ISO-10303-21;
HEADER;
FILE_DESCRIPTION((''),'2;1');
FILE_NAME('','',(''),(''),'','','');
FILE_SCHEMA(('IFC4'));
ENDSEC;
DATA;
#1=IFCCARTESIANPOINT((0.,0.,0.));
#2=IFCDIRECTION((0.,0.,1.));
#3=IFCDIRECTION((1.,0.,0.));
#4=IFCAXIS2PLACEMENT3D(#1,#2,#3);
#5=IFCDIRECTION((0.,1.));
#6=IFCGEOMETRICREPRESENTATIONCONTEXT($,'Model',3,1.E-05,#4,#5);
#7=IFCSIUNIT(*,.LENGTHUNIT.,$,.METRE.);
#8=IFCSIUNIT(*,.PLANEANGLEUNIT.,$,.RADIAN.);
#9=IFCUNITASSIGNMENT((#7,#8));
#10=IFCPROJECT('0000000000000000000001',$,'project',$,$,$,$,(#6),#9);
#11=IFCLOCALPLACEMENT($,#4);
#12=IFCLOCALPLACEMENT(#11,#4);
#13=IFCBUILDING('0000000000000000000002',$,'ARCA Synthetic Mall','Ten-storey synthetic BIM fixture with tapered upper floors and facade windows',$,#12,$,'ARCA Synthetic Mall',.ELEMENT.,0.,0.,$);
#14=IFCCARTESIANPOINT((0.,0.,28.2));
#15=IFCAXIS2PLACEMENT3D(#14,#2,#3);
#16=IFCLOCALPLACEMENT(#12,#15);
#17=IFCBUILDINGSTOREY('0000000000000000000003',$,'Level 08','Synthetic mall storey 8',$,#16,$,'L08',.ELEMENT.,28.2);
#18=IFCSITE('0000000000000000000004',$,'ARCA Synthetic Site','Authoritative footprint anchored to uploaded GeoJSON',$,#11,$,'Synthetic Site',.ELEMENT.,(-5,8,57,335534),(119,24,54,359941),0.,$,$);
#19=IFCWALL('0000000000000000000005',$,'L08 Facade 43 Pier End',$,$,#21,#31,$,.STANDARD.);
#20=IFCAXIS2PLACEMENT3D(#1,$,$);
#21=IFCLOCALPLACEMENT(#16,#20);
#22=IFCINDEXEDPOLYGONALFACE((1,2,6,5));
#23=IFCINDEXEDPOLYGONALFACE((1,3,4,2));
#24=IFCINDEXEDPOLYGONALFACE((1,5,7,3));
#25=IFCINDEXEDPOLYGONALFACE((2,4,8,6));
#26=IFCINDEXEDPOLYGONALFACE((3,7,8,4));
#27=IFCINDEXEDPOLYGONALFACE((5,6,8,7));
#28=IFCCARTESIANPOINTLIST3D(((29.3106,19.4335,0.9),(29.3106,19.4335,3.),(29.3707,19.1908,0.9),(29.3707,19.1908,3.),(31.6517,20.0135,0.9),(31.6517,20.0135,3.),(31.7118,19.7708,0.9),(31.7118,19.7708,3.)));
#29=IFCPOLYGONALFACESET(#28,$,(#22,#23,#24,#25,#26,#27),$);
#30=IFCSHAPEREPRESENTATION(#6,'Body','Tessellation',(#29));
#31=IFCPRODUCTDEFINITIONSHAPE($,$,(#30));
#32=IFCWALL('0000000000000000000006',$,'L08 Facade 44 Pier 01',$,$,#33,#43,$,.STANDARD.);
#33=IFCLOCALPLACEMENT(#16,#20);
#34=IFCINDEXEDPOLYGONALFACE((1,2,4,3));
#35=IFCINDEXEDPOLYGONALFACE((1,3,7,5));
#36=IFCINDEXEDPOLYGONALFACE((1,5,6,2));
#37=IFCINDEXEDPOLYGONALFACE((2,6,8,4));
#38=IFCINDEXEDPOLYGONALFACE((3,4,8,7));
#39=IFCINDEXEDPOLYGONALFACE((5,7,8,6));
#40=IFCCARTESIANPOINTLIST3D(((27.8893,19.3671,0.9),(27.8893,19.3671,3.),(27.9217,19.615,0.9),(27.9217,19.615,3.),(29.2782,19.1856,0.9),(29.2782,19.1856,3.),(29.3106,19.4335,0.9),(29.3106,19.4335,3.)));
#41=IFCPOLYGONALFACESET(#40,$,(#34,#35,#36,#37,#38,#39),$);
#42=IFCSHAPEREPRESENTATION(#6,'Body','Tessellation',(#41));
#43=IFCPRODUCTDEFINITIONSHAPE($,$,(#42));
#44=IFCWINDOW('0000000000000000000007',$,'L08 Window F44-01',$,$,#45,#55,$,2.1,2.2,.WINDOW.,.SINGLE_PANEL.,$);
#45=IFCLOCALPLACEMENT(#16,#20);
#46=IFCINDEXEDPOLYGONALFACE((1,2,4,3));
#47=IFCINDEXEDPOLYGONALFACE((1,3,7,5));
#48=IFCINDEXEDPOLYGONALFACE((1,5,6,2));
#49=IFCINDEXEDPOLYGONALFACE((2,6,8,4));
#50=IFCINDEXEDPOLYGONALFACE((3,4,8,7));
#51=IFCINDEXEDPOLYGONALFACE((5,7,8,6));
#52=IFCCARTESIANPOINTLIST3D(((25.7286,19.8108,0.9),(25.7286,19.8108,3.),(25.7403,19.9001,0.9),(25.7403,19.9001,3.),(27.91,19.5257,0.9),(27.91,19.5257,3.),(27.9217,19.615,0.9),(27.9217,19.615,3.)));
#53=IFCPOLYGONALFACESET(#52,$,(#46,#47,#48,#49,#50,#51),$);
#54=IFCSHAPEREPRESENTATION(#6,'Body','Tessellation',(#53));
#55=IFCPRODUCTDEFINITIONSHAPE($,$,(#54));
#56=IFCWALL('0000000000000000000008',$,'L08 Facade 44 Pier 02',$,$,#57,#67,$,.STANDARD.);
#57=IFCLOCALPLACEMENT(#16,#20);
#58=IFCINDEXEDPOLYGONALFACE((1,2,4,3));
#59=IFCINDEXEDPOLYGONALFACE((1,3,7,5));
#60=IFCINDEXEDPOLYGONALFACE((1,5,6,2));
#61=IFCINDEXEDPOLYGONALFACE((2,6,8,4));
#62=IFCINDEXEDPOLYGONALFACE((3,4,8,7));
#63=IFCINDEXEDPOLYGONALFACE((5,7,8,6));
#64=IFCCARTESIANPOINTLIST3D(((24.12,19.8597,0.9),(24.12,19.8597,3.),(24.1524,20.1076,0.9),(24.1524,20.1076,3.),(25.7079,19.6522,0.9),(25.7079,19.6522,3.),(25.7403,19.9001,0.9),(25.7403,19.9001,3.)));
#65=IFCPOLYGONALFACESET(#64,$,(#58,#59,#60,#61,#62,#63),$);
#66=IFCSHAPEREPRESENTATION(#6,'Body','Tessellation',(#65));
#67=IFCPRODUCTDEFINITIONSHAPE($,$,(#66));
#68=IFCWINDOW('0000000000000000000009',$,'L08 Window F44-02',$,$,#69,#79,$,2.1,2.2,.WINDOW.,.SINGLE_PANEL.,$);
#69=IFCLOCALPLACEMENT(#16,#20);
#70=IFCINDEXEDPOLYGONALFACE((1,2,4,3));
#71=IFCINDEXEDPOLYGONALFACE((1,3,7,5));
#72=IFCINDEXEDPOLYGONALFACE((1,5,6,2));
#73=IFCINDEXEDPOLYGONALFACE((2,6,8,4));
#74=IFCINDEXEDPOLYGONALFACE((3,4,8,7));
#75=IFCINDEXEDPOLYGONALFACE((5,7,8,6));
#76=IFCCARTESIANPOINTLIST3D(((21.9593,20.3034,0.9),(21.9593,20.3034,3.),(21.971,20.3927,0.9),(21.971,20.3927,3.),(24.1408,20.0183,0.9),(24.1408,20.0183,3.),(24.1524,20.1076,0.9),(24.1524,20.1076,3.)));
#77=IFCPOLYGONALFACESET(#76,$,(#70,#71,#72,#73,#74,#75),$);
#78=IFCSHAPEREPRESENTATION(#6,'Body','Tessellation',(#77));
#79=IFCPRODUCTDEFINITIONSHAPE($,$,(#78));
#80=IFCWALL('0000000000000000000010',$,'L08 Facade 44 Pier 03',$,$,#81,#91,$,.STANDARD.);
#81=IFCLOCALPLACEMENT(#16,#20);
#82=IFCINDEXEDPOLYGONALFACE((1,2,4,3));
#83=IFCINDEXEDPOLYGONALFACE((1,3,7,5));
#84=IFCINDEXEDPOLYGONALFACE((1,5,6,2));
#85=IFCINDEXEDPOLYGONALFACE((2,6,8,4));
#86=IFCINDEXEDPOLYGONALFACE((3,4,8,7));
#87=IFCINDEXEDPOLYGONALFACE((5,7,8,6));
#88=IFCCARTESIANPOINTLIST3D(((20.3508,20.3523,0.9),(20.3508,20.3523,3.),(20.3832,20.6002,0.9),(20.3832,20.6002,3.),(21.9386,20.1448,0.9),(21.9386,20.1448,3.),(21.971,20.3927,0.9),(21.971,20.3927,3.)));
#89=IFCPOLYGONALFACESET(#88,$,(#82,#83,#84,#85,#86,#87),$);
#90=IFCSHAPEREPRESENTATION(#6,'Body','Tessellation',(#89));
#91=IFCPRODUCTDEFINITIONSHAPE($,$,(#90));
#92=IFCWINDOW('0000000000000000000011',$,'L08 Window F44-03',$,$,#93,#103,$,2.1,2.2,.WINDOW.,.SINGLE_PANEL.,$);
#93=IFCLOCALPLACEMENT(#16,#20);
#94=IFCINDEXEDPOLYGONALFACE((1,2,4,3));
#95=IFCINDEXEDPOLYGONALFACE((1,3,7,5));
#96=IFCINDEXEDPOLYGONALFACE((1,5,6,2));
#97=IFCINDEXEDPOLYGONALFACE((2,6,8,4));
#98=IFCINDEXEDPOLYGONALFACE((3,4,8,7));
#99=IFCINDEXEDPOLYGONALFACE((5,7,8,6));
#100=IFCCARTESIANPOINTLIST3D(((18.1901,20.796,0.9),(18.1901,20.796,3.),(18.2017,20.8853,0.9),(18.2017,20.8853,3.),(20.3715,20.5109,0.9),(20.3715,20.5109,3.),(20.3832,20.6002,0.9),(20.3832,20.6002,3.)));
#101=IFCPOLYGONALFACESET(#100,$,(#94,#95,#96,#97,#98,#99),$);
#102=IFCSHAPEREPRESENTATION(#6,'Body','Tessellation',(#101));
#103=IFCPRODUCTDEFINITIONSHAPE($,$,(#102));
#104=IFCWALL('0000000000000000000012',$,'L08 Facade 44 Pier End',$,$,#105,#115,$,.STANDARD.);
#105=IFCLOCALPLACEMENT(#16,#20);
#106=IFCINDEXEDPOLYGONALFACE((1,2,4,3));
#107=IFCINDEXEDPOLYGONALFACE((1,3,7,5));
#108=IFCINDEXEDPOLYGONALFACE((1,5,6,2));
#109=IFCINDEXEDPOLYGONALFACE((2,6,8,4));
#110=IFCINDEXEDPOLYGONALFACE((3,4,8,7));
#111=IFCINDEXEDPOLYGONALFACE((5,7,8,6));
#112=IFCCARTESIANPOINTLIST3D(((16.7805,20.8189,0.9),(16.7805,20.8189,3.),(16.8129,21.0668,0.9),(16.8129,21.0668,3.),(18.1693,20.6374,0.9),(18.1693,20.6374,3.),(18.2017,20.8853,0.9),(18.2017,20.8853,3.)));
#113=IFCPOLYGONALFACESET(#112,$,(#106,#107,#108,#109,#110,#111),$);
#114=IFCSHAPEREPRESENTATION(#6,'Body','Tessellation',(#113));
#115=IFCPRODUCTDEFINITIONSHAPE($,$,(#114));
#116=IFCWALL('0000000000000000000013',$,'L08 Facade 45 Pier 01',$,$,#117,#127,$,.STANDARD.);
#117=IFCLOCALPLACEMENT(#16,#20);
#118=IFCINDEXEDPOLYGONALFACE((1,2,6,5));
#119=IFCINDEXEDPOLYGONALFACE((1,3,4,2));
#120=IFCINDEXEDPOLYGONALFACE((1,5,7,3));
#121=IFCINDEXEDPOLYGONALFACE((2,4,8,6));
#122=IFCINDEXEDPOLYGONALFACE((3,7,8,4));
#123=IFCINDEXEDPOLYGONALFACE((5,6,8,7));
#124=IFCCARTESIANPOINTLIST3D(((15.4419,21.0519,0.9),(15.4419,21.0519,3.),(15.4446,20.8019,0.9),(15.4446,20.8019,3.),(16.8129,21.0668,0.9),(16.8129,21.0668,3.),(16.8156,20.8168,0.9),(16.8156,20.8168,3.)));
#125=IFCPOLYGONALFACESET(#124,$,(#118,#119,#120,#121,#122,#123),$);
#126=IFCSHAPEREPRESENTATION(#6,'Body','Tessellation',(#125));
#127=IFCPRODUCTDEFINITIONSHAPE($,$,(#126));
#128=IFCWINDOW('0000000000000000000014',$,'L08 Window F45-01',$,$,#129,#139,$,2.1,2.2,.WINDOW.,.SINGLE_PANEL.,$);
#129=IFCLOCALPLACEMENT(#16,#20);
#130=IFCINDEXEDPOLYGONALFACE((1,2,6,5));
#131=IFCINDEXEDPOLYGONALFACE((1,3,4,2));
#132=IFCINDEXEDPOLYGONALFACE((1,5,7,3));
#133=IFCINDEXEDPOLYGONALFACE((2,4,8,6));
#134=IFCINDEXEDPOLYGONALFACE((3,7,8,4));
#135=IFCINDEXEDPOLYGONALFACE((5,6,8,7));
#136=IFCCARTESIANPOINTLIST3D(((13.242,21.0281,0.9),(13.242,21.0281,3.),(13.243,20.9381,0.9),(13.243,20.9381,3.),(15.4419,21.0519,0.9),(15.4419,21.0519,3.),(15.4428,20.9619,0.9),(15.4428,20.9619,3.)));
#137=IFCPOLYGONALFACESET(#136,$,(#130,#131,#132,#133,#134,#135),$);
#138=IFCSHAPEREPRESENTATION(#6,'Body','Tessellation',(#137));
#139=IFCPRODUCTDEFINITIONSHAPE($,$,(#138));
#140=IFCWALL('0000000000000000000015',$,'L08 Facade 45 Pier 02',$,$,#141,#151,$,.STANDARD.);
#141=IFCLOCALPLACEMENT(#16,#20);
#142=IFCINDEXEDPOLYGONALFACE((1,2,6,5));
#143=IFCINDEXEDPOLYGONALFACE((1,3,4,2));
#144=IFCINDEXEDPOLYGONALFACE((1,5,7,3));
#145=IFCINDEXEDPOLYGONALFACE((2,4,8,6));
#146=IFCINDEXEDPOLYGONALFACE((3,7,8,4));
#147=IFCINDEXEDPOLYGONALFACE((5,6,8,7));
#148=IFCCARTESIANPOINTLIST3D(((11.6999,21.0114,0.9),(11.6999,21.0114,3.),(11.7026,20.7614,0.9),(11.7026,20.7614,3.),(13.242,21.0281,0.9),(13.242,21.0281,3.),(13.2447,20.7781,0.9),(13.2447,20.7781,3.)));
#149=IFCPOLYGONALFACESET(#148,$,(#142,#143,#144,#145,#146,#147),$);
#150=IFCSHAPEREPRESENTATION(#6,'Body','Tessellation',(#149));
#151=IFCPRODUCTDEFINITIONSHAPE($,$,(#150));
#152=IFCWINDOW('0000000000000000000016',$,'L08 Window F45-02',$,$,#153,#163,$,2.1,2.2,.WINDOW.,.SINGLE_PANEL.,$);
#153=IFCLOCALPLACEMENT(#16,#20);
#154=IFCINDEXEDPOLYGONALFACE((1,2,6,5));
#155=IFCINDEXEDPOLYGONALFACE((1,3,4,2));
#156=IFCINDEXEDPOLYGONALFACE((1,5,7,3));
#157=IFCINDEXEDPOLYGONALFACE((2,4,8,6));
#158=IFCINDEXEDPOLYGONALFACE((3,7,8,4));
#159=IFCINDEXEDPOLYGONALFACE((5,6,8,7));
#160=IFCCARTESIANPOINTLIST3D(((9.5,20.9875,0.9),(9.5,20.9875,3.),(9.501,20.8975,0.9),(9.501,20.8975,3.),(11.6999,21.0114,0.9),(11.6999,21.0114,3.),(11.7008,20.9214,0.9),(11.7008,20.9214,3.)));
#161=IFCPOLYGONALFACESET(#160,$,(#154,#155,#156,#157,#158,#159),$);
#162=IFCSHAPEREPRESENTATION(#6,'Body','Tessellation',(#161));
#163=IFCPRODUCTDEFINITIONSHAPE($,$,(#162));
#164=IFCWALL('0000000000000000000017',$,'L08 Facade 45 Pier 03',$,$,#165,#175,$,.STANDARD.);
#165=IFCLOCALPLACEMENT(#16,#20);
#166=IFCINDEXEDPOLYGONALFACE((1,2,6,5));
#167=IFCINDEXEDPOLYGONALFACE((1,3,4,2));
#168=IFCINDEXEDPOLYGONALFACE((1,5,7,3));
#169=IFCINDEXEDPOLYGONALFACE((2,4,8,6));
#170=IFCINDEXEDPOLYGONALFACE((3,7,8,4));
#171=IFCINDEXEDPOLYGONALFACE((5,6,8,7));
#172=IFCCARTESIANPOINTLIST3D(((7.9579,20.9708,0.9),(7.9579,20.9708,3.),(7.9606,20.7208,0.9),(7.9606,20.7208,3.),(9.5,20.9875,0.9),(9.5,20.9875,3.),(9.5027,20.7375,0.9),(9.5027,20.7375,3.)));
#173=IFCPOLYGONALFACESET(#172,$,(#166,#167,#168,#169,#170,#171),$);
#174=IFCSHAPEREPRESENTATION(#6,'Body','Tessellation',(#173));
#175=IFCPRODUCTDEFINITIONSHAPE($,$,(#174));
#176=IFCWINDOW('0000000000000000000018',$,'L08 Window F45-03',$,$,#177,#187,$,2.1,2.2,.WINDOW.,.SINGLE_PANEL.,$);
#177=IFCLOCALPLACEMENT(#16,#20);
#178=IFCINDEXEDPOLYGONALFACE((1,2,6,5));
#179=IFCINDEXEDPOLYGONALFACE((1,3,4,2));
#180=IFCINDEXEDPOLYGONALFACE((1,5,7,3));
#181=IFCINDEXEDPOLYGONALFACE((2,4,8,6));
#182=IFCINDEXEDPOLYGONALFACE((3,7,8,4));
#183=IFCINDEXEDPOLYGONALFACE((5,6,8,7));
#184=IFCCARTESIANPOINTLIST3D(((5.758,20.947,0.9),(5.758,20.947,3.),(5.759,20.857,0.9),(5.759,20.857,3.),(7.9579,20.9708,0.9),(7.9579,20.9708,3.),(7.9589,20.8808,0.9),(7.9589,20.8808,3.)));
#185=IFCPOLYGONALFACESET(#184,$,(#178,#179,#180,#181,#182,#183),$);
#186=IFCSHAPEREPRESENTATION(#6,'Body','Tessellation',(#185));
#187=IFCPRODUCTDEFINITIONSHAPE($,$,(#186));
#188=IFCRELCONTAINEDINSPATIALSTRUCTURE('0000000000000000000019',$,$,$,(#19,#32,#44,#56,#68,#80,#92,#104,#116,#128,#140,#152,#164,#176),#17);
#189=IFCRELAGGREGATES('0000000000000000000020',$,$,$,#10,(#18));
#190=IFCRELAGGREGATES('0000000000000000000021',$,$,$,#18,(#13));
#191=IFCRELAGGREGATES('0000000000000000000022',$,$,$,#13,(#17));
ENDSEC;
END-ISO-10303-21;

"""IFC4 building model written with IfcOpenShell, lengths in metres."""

from ifc_helpers import new_model, si_unit, direction, frame, origin_with_axes, place, context, project, spatial, polyline, outline, extrude, element, save


model = new_model("IFC4")

# Units and contexts
model_context = context("Model", 3, precision=1e-05, world=origin_with_axes(), true_north=direction((0.0, 1.0)))
ifc_project = project(units=[si_unit("LENGTHUNIT", "METRE"), si_unit("PLANEANGLEUNIT", "RADIAN")], contexts=[model_context])

# Site, building, storey
site_placement = place(None, origin_with_axes())
site = spatial("IfcSite", under=ifc_project, at=site_placement, Name="ARCA Synthetic Site", Description="Authoritative footprint anchored to uploaded GeoJSON", LongName="Synthetic Site", CompositionType="ELEMENT", RefLatitude=(-5, 8, 57, 335534), RefLongitude=(119, 24, 54, 359941), RefElevation=0.0)
building_placement = place(site_placement, origin_with_axes())
building = spatial("IfcBuilding", under=site, at=building_placement, Name="ARCA Synthetic Mall", Description="Ten-storey synthetic BIM fixture with tapered upper floors and facade windows", LongName="ARCA Synthetic Mall", CompositionType="ELEMENT", ElevationOfRefHeight=0.0, ElevationOfTerrain=0.0)
storey_placement = place(building_placement, frame((0.0, 0.0, 28.2), z_axis=(0.0, 0.0, 1.0), x_axis=(1.0, 0.0, 0.0)))
storey = spatial("IfcBuildingStorey", under=building, at=storey_placement, Name="Level 08", Description="Synthetic mall storey 8", LongName="L08", CompositionType="ELEMENT", Elevation=28.2)

# Walls
wall_1_placement = place(storey_placement, frame((0.0, 0.0, 0.9), z_axis=(0.0, 0.0, 1.0), x_axis=(1.0, 0.0, 0.0)))
element("IfcWall", 1, at=wall_1_placement, inside=storey, Name="L08 Facade 43 Pier End", PredefinedType="STANDARD", context=model_context, shape_type="SweptSolid", body=[
    extrude(outline(polyline([(31.6517, 20.0135), (29.3105, 19.4335), (29.3707, 19.1908), (31.7118, 19.7708), (31.6517, 20.0135)])), origin_with_axes(), (0.0, 0.0, 1.0), 2.1),
])
wall_2_placement = place(storey_placement, frame((0.0, 0.0, 0.9), z_axis=(0.0, 0.0, 1.0), x_axis=(1.0, 0.0, 0.0)))
element("IfcWall", 2, at=wall_2_placement, inside=storey, Name="L08 Facade 44 Pier 01", PredefinedType="STANDARD", context=model_context, shape_type="SweptSolid", body=[
    extrude(outline(polyline([(29.3105, 19.4335), (27.9217, 19.615), (27.8893, 19.3671), (29.2782, 19.1856), (29.3105, 19.4335)])), origin_with_axes(), (0.0, 0.0, 1.0), 2.1),
])

# Window
window_1_placement = place(storey_placement, frame((0.0, 0.0, 0.9), z_axis=(0.0, 0.0, 1.0), x_axis=(1.0, 0.0, 0.0)))
element("IfcWindow", 3, at=window_1_placement, inside=storey, Name="L08 Window F44-01", OverallHeight=2.1, OverallWidth=2.2, PartitioningType="SINGLE_PANEL", PredefinedType="WINDOW", context=model_context, shape_type="SweptSolid", body=[
    extrude(outline(polyline([(27.9217, 19.615), (25.7403, 19.9001), (25.7286, 19.8108), (27.91, 19.5257), (27.9217, 19.615)])), origin_with_axes(), (0.0, 0.0, 1.0), 2.1),
])

# Wall
wall_3_placement = place(storey_placement, frame((0.0, 0.0, 0.9), z_axis=(0.0, 0.0, 1.0), x_axis=(1.0, 0.0, 0.0)))
element("IfcWall", 4, at=wall_3_placement, inside=storey, Name="L08 Facade 44 Pier 02", PredefinedType="STANDARD", context=model_context, shape_type="SweptSolid", body=[
    extrude(outline(polyline([(25.7403, 19.9001), (24.1524, 20.1076), (24.12, 19.8597), (25.7079, 19.6522), (25.7403, 19.9001)])), origin_with_axes(), (0.0, 0.0, 1.0), 2.1),
])

# Window
window_2_placement = place(storey_placement, frame((0.0, 0.0, 0.9), z_axis=(0.0, 0.0, 1.0), x_axis=(1.0, 0.0, 0.0)))
element("IfcWindow", 5, at=window_2_placement, inside=storey, Name="L08 Window F44-02", OverallHeight=2.1, OverallWidth=2.2, PartitioningType="SINGLE_PANEL", PredefinedType="WINDOW", context=model_context, shape_type="SweptSolid", body=[
    extrude(outline(polyline([(24.1524, 20.1076), (21.971, 20.3927), (21.9593, 20.3034), (24.1408, 20.0183), (24.1524, 20.1076)])), origin_with_axes(), (0.0, 0.0, 1.0), 2.1),
])

# Wall
wall_4_placement = place(storey_placement, frame((0.0, 0.0, 0.9), z_axis=(0.0, 0.0, 1.0), x_axis=(1.0, 0.0, 0.0)))
element("IfcWall", 6, at=wall_4_placement, inside=storey, Name="L08 Facade 44 Pier 03", PredefinedType="STANDARD", context=model_context, shape_type="SweptSolid", body=[
    extrude(outline(polyline([(21.971, 20.3927), (20.3832, 20.6002), (20.3508, 20.3523), (21.9386, 20.1448), (21.971, 20.3927)])), origin_with_axes(), (0.0, 0.0, 1.0), 2.1),
])

# Window
window_3_placement = place(storey_placement, frame((0.0, 0.0, 0.9), z_axis=(0.0, 0.0, 1.0), x_axis=(1.0, 0.0, 0.0)))
element("IfcWindow", 7, at=window_3_placement, inside=storey, Name="L08 Window F44-03", OverallHeight=2.1, OverallWidth=2.2, PartitioningType="SINGLE_PANEL", PredefinedType="WINDOW", context=model_context, shape_type="SweptSolid", body=[
    extrude(outline(polyline([(20.3832, 20.6002), (18.2017, 20.8853), (18.1901, 20.796), (20.3715, 20.5109), (20.3832, 20.6002)])), origin_with_axes(), (0.0, 0.0, 1.0), 2.1),
])

# Walls
wall_5_placement = place(storey_placement, frame((0.0, 0.0, 0.9), z_axis=(0.0, 0.0, 1.0), x_axis=(1.0, 0.0, 0.0)))
element("IfcWall", 8, at=wall_5_placement, inside=storey, Name="L08 Facade 44 Pier End", PredefinedType="STANDARD", context=model_context, shape_type="SweptSolid", body=[
    extrude(outline(polyline([(18.2017, 20.8853), (16.8129, 21.0668), (16.7805, 20.8189), (18.1693, 20.6374), (18.2017, 20.8853)])), origin_with_axes(), (0.0, 0.0, 1.0), 2.1),
])
wall_6_placement = place(storey_placement, frame((0.0, 0.0, 0.9), z_axis=(0.0, 0.0, 1.0), x_axis=(1.0, 0.0, 0.0)))
element("IfcWall", 9, at=wall_6_placement, inside=storey, Name="L08 Facade 45 Pier 01", PredefinedType="STANDARD", context=model_context, shape_type="SweptSolid", body=[
    extrude(outline(polyline([(16.8129, 21.0668), (15.4419, 21.0519), (15.4446, 20.8019), (16.8156, 20.8168), (16.8129, 21.0668)])), origin_with_axes(), (0.0, 0.0, 1.0), 2.1),
])

# Window
window_4_placement = place(storey_placement, frame((0.0, 0.0, 0.9), z_axis=(0.0, 0.0, 1.0), x_axis=(1.0, 0.0, 0.0)))
element("IfcWindow", 10, at=window_4_placement, inside=storey, Name="L08 Window F45-01", OverallHeight=2.1, OverallWidth=2.2, PartitioningType="SINGLE_PANEL", PredefinedType="WINDOW", context=model_context, shape_type="SweptSolid", body=[
    extrude(outline(polyline([(15.4419, 21.0519), (13.242, 21.0281), (13.243, 20.9381), (15.4428, 20.9619), (15.4419, 21.0519)])), origin_with_axes(), (0.0, 0.0, 1.0), 2.1),
])

# Wall
wall_7_placement = place(storey_placement, frame((0.0, 0.0, 0.9), z_axis=(0.0, 0.0, 1.0), x_axis=(1.0, 0.0, 0.0)))
element("IfcWall", 11, at=wall_7_placement, inside=storey, Name="L08 Facade 45 Pier 02", PredefinedType="STANDARD", context=model_context, shape_type="SweptSolid", body=[
    extrude(outline(polyline([(13.242, 21.0281), (11.6999, 21.0114), (11.7026, 20.7614), (13.2447, 20.7781), (13.242, 21.0281)])), origin_with_axes(), (0.0, 0.0, 1.0), 2.1),
])

# Window
window_5_placement = place(storey_placement, frame((0.0, 0.0, 0.9), z_axis=(0.0, 0.0, 1.0), x_axis=(1.0, 0.0, 0.0)))
element("IfcWindow", 12, at=window_5_placement, inside=storey, Name="L08 Window F45-02", OverallHeight=2.1, OverallWidth=2.2, PartitioningType="SINGLE_PANEL", PredefinedType="WINDOW", context=model_context, shape_type="SweptSolid", body=[
    extrude(outline(polyline([(11.6999, 21.0114), (9.5, 20.9875), (9.501, 20.8975), (11.7008, 20.9214), (11.6999, 21.0114)])), origin_with_axes(), (0.0, 0.0, 1.0), 2.1),
])

# Wall
wall_8_placement = place(storey_placement, frame((0.0, 0.0, 0.9), z_axis=(0.0, 0.0, 1.0), x_axis=(1.0, 0.0, 0.0)))
element("IfcWall", 13, at=wall_8_placement, inside=storey, Name="L08 Facade 45 Pier 03", PredefinedType="STANDARD", context=model_context, shape_type="SweptSolid", body=[
    extrude(outline(polyline([(9.5, 20.9875), (7.9579, 20.9708), (7.9606, 20.7208), (9.5027, 20.7375), (9.5, 20.9875)])), origin_with_axes(), (0.0, 0.0, 1.0), 2.1),
])

# Window
window_6_placement = place(storey_placement, frame((0.0, 0.0, 0.9), z_axis=(0.0, 0.0, 1.0), x_axis=(1.0, 0.0, 0.0)))
element("IfcWindow", 14, at=window_6_placement, inside=storey, Name="L08 Window F45-03", OverallHeight=2.1, OverallWidth=2.2, PartitioningType="SINGLE_PANEL", PredefinedType="WINDOW", context=model_context, shape_type="SweptSolid", body=[
    extrude(outline(polyline([(7.9579, 20.9708), (5.758, 20.947), (5.759, 20.857), (7.9589, 20.8808), (7.9579, 20.9708)])), origin_with_axes(), (0.0, 0.0, 1.0), 2.1),
])

save(model, "model.ifc")
